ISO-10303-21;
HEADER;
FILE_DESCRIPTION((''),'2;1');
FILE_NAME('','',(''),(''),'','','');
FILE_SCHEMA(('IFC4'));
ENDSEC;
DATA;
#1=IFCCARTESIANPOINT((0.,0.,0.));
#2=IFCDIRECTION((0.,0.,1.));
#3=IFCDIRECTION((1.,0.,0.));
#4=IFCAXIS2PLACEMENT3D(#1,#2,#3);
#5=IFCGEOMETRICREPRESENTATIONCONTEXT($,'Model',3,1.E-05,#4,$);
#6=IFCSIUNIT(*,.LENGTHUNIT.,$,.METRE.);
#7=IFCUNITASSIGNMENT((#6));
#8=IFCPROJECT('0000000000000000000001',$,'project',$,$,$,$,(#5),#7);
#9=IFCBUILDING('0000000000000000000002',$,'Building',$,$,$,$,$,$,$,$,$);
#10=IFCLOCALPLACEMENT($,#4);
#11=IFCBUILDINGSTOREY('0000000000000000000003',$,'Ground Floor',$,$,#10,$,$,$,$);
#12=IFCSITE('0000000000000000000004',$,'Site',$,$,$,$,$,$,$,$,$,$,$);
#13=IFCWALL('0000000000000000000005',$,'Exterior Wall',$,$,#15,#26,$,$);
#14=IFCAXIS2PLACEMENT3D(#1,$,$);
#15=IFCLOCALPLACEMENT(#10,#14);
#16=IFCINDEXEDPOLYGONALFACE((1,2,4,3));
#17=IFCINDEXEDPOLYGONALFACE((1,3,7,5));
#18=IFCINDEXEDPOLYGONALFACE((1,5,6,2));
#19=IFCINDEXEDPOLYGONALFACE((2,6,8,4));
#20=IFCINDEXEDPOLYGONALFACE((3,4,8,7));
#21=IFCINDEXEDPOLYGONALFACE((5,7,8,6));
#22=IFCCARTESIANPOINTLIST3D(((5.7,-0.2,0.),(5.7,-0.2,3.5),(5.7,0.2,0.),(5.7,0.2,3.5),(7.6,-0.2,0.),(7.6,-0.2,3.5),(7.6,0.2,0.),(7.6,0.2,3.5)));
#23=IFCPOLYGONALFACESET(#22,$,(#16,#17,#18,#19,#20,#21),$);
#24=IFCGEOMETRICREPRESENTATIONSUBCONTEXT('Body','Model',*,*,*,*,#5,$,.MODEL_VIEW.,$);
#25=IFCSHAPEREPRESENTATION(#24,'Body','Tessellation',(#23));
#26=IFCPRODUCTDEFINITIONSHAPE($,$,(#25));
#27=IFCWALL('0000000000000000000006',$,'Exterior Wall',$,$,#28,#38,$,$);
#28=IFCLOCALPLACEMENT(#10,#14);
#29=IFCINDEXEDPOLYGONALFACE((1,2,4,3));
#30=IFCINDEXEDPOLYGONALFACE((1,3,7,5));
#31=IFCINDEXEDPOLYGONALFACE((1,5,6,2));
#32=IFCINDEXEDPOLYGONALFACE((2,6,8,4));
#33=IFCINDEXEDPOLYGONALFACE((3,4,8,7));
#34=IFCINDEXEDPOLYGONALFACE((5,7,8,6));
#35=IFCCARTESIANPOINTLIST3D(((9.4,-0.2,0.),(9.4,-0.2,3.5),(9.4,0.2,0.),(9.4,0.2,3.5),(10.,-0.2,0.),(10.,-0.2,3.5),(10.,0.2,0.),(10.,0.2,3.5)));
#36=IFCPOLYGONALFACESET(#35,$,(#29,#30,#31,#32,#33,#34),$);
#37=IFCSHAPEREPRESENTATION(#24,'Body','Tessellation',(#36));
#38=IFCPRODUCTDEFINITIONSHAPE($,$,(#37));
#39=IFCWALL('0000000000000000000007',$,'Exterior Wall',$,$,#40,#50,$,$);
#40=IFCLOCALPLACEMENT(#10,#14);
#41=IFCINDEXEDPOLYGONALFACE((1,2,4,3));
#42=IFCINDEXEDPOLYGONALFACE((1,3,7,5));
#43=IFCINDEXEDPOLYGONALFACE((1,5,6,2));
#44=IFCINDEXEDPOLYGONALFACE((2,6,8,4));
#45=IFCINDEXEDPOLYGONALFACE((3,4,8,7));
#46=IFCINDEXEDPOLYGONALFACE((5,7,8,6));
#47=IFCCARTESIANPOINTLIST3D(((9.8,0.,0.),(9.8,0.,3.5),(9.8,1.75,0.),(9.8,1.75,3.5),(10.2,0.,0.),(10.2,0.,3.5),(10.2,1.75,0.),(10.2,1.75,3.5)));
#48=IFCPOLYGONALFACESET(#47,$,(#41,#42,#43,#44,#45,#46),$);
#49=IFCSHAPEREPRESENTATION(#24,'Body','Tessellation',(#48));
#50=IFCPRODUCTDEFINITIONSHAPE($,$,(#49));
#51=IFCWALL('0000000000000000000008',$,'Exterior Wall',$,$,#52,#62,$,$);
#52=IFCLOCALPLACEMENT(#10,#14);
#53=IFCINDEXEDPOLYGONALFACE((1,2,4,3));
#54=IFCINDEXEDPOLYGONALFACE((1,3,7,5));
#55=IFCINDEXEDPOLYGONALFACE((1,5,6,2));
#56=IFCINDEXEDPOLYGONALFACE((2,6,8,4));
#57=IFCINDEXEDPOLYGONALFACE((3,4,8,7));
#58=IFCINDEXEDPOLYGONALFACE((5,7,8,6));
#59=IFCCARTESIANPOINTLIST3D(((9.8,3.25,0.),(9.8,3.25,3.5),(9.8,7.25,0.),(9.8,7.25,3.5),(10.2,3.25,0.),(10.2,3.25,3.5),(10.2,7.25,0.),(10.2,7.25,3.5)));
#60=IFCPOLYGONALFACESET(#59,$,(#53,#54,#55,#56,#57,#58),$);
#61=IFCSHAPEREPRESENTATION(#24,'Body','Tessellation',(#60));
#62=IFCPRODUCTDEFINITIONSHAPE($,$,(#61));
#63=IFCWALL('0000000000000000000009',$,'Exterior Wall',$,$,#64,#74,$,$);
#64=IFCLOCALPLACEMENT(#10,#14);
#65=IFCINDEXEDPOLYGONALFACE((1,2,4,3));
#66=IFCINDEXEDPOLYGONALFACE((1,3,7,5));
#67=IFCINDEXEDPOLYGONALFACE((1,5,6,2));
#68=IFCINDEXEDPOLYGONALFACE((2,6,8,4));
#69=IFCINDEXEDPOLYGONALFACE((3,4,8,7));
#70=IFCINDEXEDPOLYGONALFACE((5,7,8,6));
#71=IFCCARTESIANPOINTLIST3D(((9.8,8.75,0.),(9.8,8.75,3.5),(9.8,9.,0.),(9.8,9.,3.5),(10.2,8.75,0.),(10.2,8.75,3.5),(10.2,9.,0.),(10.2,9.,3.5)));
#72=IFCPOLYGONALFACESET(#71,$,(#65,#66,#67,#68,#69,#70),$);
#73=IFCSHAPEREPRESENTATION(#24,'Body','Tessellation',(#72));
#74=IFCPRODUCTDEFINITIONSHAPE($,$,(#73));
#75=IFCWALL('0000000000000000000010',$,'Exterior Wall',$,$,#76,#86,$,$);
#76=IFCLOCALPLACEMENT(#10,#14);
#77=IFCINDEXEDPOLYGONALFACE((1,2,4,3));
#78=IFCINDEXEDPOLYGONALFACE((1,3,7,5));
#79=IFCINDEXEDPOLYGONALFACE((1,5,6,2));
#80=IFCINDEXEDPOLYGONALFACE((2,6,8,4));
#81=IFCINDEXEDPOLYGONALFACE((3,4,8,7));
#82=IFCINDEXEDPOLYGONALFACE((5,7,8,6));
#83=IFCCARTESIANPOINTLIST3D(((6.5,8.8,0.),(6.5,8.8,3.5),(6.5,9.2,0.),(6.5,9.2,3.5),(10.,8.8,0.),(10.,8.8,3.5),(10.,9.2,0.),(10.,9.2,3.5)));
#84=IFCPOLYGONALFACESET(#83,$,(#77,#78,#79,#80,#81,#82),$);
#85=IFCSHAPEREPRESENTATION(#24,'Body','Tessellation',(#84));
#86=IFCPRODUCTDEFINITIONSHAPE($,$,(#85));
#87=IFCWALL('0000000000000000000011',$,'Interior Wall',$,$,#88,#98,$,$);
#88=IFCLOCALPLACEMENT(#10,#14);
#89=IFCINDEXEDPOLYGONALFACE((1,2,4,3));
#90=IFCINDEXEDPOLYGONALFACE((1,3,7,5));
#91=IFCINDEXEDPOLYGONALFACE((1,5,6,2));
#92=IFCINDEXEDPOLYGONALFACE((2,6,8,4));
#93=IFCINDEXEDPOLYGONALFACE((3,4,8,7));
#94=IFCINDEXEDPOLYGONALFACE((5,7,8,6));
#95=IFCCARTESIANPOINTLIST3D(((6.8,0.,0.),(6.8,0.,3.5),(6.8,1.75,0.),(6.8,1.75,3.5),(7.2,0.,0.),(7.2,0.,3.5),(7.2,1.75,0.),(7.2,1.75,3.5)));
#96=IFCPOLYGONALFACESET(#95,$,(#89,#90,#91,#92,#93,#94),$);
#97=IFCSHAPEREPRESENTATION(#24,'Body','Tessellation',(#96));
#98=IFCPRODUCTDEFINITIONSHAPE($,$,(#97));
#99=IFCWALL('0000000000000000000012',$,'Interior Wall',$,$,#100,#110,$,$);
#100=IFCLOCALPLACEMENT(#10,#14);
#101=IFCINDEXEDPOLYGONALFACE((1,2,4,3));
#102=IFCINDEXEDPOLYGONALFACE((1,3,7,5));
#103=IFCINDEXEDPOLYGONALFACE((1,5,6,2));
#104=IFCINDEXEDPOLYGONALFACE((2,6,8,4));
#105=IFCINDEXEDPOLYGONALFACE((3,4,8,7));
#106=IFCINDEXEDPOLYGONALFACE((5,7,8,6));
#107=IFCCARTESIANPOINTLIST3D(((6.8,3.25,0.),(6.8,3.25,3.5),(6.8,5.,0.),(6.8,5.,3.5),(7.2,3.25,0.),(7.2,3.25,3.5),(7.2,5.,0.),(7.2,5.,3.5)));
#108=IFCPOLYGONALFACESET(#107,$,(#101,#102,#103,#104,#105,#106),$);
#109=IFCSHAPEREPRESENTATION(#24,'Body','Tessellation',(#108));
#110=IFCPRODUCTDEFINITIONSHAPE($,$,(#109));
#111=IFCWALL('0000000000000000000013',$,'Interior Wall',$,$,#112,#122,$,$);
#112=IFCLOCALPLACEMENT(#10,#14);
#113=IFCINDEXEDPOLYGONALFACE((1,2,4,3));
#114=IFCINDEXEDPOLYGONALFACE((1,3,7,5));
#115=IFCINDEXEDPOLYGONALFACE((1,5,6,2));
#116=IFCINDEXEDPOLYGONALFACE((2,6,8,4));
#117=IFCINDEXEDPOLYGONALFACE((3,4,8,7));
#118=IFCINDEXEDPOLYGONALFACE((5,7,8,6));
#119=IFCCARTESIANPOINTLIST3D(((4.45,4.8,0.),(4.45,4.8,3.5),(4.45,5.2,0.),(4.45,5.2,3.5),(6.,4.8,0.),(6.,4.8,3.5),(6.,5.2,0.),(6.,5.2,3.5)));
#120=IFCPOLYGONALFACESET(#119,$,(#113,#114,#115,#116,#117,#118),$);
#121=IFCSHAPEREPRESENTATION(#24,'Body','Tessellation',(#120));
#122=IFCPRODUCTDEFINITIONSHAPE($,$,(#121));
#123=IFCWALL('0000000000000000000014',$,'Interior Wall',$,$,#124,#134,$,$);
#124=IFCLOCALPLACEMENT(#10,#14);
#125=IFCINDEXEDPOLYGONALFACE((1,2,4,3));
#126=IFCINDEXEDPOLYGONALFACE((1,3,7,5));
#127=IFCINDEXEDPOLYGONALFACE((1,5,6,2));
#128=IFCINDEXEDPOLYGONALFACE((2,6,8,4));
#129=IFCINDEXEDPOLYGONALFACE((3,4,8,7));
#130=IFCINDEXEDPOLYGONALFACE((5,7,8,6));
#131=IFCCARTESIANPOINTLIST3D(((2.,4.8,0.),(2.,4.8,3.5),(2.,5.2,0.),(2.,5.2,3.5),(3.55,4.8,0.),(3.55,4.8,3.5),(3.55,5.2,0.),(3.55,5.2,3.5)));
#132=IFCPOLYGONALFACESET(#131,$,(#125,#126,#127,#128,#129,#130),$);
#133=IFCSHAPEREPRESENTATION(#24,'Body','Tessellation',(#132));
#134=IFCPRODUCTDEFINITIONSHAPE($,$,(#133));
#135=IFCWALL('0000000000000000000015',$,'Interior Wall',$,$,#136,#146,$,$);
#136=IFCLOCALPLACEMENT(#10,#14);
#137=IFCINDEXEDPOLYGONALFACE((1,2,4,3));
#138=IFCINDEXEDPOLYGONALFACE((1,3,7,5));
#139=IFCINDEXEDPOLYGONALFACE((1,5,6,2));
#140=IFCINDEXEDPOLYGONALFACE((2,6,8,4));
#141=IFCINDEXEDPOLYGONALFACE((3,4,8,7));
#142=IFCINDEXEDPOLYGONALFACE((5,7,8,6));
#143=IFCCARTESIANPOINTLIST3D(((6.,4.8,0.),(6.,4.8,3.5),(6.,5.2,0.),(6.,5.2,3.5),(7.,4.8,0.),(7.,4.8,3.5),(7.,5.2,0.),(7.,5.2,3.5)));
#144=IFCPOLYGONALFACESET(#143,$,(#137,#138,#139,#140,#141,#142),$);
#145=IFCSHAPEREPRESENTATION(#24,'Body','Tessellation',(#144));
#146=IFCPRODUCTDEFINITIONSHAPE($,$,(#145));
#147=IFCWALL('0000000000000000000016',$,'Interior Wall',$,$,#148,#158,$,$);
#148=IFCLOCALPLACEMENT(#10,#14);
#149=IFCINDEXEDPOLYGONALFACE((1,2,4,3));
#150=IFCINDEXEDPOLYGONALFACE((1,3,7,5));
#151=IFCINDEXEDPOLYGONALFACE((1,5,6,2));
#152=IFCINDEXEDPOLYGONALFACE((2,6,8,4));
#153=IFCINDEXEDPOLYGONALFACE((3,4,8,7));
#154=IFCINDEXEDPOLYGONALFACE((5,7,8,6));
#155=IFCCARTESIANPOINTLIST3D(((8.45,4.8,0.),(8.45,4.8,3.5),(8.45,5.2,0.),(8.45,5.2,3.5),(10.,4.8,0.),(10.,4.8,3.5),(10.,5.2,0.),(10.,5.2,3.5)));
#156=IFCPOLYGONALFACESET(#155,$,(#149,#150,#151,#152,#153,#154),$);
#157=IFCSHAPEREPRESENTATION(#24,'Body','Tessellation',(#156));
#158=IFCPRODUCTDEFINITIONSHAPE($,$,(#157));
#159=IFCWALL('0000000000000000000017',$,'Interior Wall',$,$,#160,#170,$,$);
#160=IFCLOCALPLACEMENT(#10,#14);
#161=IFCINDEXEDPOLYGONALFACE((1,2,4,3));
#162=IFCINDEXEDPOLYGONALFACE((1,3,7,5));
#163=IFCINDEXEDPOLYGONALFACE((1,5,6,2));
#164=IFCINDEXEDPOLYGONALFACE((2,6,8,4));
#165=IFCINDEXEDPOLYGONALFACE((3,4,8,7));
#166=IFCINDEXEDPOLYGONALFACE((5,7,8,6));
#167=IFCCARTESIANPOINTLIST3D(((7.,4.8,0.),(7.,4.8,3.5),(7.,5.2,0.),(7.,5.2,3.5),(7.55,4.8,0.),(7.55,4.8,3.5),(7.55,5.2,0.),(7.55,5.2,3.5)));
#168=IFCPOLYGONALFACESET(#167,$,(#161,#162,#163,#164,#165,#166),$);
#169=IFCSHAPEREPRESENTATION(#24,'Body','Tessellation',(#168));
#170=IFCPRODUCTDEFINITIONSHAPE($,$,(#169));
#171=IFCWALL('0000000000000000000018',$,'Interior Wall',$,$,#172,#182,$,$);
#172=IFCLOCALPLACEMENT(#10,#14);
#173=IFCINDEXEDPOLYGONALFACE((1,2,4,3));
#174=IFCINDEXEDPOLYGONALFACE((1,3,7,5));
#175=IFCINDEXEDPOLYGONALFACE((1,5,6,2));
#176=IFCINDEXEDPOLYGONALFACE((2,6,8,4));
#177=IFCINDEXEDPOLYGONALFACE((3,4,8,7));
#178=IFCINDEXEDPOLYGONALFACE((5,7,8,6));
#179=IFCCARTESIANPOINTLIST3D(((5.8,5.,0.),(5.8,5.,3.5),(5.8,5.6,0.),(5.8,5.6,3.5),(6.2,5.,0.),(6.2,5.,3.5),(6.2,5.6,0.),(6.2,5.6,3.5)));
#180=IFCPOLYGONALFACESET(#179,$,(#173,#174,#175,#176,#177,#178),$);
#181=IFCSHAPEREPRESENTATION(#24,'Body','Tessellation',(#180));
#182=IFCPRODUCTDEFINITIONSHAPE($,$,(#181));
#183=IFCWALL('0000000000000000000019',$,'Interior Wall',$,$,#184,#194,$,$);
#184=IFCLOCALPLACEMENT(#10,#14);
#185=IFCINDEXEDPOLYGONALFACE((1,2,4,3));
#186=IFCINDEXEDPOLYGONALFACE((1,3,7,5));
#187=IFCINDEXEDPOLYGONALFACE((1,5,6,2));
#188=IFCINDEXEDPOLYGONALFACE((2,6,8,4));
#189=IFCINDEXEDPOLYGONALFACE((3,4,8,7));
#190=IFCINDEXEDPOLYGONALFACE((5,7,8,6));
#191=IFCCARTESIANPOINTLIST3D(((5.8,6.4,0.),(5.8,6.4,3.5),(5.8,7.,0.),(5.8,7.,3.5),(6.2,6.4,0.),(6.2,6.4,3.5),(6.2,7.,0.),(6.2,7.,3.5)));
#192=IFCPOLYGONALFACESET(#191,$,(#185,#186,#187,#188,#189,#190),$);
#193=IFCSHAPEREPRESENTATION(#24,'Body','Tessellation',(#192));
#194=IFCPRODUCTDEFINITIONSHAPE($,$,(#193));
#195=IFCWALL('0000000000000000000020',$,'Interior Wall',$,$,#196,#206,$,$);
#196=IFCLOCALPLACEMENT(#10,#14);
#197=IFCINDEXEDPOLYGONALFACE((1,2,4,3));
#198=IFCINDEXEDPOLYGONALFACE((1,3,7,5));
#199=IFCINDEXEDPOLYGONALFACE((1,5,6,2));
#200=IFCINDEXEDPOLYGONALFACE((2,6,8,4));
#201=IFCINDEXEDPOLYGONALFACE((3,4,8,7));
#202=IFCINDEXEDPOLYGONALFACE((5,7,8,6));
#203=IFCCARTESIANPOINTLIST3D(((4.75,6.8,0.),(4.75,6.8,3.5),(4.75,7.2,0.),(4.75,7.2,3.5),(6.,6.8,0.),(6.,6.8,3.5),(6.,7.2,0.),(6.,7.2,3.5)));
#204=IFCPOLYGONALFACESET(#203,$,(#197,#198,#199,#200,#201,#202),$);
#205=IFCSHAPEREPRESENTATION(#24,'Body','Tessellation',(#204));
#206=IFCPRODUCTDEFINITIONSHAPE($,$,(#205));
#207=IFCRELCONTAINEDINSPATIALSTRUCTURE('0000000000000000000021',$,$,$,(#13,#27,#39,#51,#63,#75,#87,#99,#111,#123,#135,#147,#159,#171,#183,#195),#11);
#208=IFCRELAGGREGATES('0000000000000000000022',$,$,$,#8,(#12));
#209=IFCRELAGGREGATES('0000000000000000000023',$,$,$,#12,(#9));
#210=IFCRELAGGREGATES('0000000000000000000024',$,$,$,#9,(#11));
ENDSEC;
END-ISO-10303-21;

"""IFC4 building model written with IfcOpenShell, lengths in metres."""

from ifc_helpers import new_model, si_unit, frame, origin_with_axes, place, context, subcontext, project, spatial, indexed_curve, outline, extrude, element, save


model = new_model("IFC4")

# Units and contexts
model_context = context("Model", 3, precision=1e-05, world=origin_with_axes())
body_context = subcontext(model_context, "Body", "Model", "MODEL_VIEW")
ifc_project = project(units=[si_unit("LENGTHUNIT", "METRE")], contexts=[model_context])

# Site, building, storey
site = spatial("IfcSite", under=ifc_project, Name="Site")
building = spatial("IfcBuilding", under=site, Name="Building")
storey_placement = place(None, origin_with_axes())
storey = spatial("IfcBuildingStorey", under=building, at=storey_placement, Name="Ground Floor")

# Walls
wall_1_placement = place(storey_placement, frame((5.7, 0.0, 0.0), z_axis=(0.0, 0.0, 1.0), x_axis=(1.0, 0.0, 0.0)))
element("IfcWall", 1, at=wall_1_placement, inside=storey, Name="Exterior Wall", context=body_context, shape_type="SweptSolid", body=[
    extrude(outline(indexed_curve([(0.0, 0.0), (0.0, 0.4), (1.9, 0.4), (1.9, 0.0), (0.0, 0.0)], self_intersect=False)), frame((0.0, -0.2, 0.0), z_axis=(0.0, 0.0, 1.0), x_axis=(1.0, 0.0, 0.0)), (0.0, 0.0, 1.0), 3.5),
])
wall_2_placement = place(storey_placement, frame((9.4, 0.0, 0.0), z_axis=(0.0, 0.0, 1.0), x_axis=(1.0, 0.0, 0.0)))
element("IfcWall", 2, at=wall_2_placement, inside=storey, Name="Exterior Wall", context=body_context, shape_type="SweptSolid", body=[
    extrude(outline(indexed_curve([(0.0, 0.0), (0.0, 0.4), (0.6, 0.4), (0.6, 0.0), (0.0, 0.0)], self_intersect=False)), frame((0.0, -0.2, 0.0), z_axis=(0.0, 0.0, 1.0), x_axis=(1.0, 0.0, 0.0)), (0.0, 0.0, 1.0), 3.5),
])
wall_3_placement = place(storey_placement, frame((10.0, 0.0, 0.0), z_axis=(0.0, 0.0, 1.0), x_axis=(0.0, 1.0, 0.0)))
element("IfcWall", 3, at=wall_3_placement, inside=storey, Name="Exterior Wall", context=body_context, shape_type="SweptSolid", body=[
    extrude(outline(indexed_curve([(0.0, 0.0), (0.0, 0.4), (1.75, 0.4), (1.75, 0.0), (0.0, 0.0)], self_intersect=False)), frame((0.0, -0.2, 0.0), z_axis=(0.0, 0.0, 1.0), x_axis=(1.0, 0.0, 0.0)), (0.0, 0.0, 1.0), 3.5),
])
wall_4_placement = place(storey_placement, frame((10.0, 3.25, 0.0), z_axis=(0.0, 0.0, 1.0), x_axis=(0.0, 1.0, 0.0)))
element("IfcWall", 4, at=wall_4_placement, inside=storey, Name="Exterior Wall", context=body_context, shape_type="SweptSolid", body=[
    extrude(outline(indexed_curve([(0.0, 0.0), (0.0, 0.4), (4.0, 0.4), (4.0, 0.0), (0.0, 0.0)], self_intersect=False)), frame((0.0, -0.2, 0.0), z_axis=(0.0, 0.0, 1.0), x_axis=(1.0, 0.0, 0.0)), (0.0, 0.0, 1.0), 3.5),
])
wall_5_placement = place(storey_placement, frame((10.0, 8.75, 0.0), z_axis=(0.0, 0.0, 1.0), x_axis=(0.0, 1.0, 0.0)))
element("IfcWall", 5, at=wall_5_placement, inside=storey, Name="Exterior Wall", context=body_context, shape_type="SweptSolid", body=[
    extrude(outline(indexed_curve([(0.0, 0.0), (0.0, 0.4), (0.25, 0.4), (0.25, 0.0), (0.0, 0.0)], self_intersect=False)), frame((0.0, -0.2, 0.0), z_axis=(0.0, 0.0, 1.0), x_axis=(1.0, 0.0, 0.0)), (0.0, 0.0, 1.0), 3.5),
])
wall_6_placement = place(storey_placement, frame((10.0, 9.0, 0.0), z_axis=(0.0, 0.0, 1.0), x_axis=(-1.0, 0.0, 0.0)))
element("IfcWall", 6, at=wall_6_placement, inside=storey, Name="Exterior Wall", context=body_context, shape_type="SweptSolid", body=[
    extrude(outline(indexed_curve([(0.0, 0.0), (0.0, 0.4), (3.5, 0.4), (3.5, 0.0), (0.0, 0.0)], self_intersect=False)), frame((0.0, -0.2, 0.0), z_axis=(0.0, 0.0, 1.0), x_axis=(1.0, 0.0, 0.0)), (0.0, 0.0, 1.0), 3.5),
])
for number, where, z_axis, x_axis, name in (
    (7, (7.0, 0.0, 0.0), (0.0, 0.0, 1.0), (0.0, 1.0, 0.0), "Interior Wall"),
    (8, (7.0, 3.25, 0.0), (0.0, 0.0, 1.0), (0.0, 1.0, 0.0), "Interior Wall"),
):
    element("IfcWall", number, at=place(storey_placement, frame(where, z_axis=z_axis, x_axis=x_axis)), inside=storey, Name=name, context=body_context, shape_type="SweptSolid", body=[
        extrude(outline(indexed_curve([(0.0, 0.0), (0.0, 0.4), (1.75, 0.4), (1.75, 0.0), (0.0, 0.0)], self_intersect=False)), frame((0.0, -0.2, 0.0), z_axis=(0.0, 0.0, 1.0), x_axis=(1.0, 0.0, 0.0)), (0.0, 0.0, 1.0), 3.5),
    ])
for number, where, z_axis, x_axis, name in (
    (9, (6.0, 5.0, 0.0), (0.0, 0.0, 1.0), (-1.0, 0.0, 0.0), "Interior Wall"),
    (10, (3.55, 5.0, 0.0), (0.0, 0.0, 1.0), (-1.0, 0.0, 0.0), "Interior Wall"),
):
    element("IfcWall", number, at=place(storey_placement, frame(where, z_axis=z_axis, x_axis=x_axis)), inside=storey, Name=name, context=body_context, shape_type="SweptSolid", body=[
        extrude(outline(indexed_curve([(0.0, 0.0), (0.0, 0.4), (1.55, 0.4), (1.55, 0.0), (0.0, 0.0)], self_intersect=False)), frame((0.0, -0.2, 0.0), z_axis=(0.0, 0.0, 1.0), x_axis=(1.0, 0.0, 0.0)), (0.0, 0.0, 1.0), 3.5),
    ])
wall_7_placement = place(storey_placement, frame((7.0, 5.0, 0.0), z_axis=(0.0, 0.0, 1.0), x_axis=(-1.0, 0.0, 0.0)))
element("IfcWall", 11, at=wall_7_placement, inside=storey, Name="Interior Wall", context=body_context, shape_type="SweptSolid", body=[
    extrude(outline(indexed_curve([(0.0, 0.0), (0.0, 0.4), (1.0, 0.4), (1.0, 0.0), (0.0, 0.0)], self_intersect=False)), frame((0.0, -0.2, 0.0), z_axis=(0.0, 0.0, 1.0), x_axis=(1.0, 0.0, 0.0)), (0.0, 0.0, 1.0), 3.5),
])
wall_8_placement = place(storey_placement, frame((10.0, 5.0, 0.0), z_axis=(0.0, 0.0, 1.0), x_axis=(-1.0, 0.0, 0.0)))
element("IfcWall", 12, at=wall_8_placement, inside=storey, Name="Interior Wall", context=body_context, shape_type="SweptSolid", body=[
    extrude(outline(indexed_curve([(0.0, 0.0), (0.0, 0.4), (1.55, 0.4), (1.55, 0.0), (0.0, 0.0)], self_intersect=False)), frame((0.0, -0.2, 0.0), z_axis=(0.0, 0.0, 1.0), x_axis=(1.0, 0.0, 0.0)), (0.0, 0.0, 1.0), 3.5),
])
wall_9_placement = place(storey_placement, frame((7.55, 5.0, 0.0), z_axis=(0.0, 0.0, 1.0), x_axis=(-1.0, 0.0, 0.0)))
element("IfcWall", 13, at=wall_9_placement, inside=storey, Name="Interior Wall", context=body_context, shape_type="SweptSolid", body=[
    extrude(outline(indexed_curve([(0.0, 0.0), (0.0, 0.4), (0.55, 0.4), (0.55, 0.0), (0.0, 0.0)], self_intersect=False)), frame((0.0, -0.2, 0.0), z_axis=(0.0, 0.0, 1.0), x_axis=(1.0, 0.0, 0.0)), (0.0, 0.0, 1.0), 3.5),
])
for number, where, z_axis, x_axis, name in (
    (14, (6.0, 5.0, 0.0), (0.0, 0.0, 1.0), (0.0, 1.0, 0.0), "Interior Wall"),
    (15, (6.0, 6.4, 0.0), (0.0, 0.0, 1.0), (0.0, 1.0, 0.0), "Interior Wall"),
):
    element("IfcWall", number, at=place(storey_placement, frame(where, z_axis=z_axis, x_axis=x_axis)), inside=storey, Name=name, context=body_context, shape_type="SweptSolid", body=[
        extrude(outline(indexed_curve([(0.0, 0.0), (0.0, 0.4), (0.6, 0.4), (0.6, 0.0), (0.0, 0.0)], self_intersect=False)), frame((0.0, -0.2, 0.0), z_axis=(0.0, 0.0, 1.0), x_axis=(1.0, 0.0, 0.0)), (0.0, 0.0, 1.0), 3.5),
    ])
for number, where, z_axis, x_axis, name in (
    (16, (6.0, 7.0, 0.0), (0.0, 0.0, 1.0), (-1.0, 0.0, 0.0), "Interior Wall"),
):
    element("IfcWall", number, at=place(storey_placement, frame(where, z_axis=z_axis, x_axis=x_axis)), inside=storey, Name=name, context=body_context, shape_type="SweptSolid", body=[
        extrude(outline(indexed_curve([(0.0, 0.0), (0.0, 0.4), (1.25, 0.4), (1.25, 0.0), (0.0, 0.0)], self_intersect=False)), frame((0.0, -0.2, 0.0), z_axis=(0.0, 0.0, 1.0), x_axis=(1.0, 0.0, 0.0)), (0.0, 0.0, 1.0), 3.5),
    ])

save(model, "model.ifc")
